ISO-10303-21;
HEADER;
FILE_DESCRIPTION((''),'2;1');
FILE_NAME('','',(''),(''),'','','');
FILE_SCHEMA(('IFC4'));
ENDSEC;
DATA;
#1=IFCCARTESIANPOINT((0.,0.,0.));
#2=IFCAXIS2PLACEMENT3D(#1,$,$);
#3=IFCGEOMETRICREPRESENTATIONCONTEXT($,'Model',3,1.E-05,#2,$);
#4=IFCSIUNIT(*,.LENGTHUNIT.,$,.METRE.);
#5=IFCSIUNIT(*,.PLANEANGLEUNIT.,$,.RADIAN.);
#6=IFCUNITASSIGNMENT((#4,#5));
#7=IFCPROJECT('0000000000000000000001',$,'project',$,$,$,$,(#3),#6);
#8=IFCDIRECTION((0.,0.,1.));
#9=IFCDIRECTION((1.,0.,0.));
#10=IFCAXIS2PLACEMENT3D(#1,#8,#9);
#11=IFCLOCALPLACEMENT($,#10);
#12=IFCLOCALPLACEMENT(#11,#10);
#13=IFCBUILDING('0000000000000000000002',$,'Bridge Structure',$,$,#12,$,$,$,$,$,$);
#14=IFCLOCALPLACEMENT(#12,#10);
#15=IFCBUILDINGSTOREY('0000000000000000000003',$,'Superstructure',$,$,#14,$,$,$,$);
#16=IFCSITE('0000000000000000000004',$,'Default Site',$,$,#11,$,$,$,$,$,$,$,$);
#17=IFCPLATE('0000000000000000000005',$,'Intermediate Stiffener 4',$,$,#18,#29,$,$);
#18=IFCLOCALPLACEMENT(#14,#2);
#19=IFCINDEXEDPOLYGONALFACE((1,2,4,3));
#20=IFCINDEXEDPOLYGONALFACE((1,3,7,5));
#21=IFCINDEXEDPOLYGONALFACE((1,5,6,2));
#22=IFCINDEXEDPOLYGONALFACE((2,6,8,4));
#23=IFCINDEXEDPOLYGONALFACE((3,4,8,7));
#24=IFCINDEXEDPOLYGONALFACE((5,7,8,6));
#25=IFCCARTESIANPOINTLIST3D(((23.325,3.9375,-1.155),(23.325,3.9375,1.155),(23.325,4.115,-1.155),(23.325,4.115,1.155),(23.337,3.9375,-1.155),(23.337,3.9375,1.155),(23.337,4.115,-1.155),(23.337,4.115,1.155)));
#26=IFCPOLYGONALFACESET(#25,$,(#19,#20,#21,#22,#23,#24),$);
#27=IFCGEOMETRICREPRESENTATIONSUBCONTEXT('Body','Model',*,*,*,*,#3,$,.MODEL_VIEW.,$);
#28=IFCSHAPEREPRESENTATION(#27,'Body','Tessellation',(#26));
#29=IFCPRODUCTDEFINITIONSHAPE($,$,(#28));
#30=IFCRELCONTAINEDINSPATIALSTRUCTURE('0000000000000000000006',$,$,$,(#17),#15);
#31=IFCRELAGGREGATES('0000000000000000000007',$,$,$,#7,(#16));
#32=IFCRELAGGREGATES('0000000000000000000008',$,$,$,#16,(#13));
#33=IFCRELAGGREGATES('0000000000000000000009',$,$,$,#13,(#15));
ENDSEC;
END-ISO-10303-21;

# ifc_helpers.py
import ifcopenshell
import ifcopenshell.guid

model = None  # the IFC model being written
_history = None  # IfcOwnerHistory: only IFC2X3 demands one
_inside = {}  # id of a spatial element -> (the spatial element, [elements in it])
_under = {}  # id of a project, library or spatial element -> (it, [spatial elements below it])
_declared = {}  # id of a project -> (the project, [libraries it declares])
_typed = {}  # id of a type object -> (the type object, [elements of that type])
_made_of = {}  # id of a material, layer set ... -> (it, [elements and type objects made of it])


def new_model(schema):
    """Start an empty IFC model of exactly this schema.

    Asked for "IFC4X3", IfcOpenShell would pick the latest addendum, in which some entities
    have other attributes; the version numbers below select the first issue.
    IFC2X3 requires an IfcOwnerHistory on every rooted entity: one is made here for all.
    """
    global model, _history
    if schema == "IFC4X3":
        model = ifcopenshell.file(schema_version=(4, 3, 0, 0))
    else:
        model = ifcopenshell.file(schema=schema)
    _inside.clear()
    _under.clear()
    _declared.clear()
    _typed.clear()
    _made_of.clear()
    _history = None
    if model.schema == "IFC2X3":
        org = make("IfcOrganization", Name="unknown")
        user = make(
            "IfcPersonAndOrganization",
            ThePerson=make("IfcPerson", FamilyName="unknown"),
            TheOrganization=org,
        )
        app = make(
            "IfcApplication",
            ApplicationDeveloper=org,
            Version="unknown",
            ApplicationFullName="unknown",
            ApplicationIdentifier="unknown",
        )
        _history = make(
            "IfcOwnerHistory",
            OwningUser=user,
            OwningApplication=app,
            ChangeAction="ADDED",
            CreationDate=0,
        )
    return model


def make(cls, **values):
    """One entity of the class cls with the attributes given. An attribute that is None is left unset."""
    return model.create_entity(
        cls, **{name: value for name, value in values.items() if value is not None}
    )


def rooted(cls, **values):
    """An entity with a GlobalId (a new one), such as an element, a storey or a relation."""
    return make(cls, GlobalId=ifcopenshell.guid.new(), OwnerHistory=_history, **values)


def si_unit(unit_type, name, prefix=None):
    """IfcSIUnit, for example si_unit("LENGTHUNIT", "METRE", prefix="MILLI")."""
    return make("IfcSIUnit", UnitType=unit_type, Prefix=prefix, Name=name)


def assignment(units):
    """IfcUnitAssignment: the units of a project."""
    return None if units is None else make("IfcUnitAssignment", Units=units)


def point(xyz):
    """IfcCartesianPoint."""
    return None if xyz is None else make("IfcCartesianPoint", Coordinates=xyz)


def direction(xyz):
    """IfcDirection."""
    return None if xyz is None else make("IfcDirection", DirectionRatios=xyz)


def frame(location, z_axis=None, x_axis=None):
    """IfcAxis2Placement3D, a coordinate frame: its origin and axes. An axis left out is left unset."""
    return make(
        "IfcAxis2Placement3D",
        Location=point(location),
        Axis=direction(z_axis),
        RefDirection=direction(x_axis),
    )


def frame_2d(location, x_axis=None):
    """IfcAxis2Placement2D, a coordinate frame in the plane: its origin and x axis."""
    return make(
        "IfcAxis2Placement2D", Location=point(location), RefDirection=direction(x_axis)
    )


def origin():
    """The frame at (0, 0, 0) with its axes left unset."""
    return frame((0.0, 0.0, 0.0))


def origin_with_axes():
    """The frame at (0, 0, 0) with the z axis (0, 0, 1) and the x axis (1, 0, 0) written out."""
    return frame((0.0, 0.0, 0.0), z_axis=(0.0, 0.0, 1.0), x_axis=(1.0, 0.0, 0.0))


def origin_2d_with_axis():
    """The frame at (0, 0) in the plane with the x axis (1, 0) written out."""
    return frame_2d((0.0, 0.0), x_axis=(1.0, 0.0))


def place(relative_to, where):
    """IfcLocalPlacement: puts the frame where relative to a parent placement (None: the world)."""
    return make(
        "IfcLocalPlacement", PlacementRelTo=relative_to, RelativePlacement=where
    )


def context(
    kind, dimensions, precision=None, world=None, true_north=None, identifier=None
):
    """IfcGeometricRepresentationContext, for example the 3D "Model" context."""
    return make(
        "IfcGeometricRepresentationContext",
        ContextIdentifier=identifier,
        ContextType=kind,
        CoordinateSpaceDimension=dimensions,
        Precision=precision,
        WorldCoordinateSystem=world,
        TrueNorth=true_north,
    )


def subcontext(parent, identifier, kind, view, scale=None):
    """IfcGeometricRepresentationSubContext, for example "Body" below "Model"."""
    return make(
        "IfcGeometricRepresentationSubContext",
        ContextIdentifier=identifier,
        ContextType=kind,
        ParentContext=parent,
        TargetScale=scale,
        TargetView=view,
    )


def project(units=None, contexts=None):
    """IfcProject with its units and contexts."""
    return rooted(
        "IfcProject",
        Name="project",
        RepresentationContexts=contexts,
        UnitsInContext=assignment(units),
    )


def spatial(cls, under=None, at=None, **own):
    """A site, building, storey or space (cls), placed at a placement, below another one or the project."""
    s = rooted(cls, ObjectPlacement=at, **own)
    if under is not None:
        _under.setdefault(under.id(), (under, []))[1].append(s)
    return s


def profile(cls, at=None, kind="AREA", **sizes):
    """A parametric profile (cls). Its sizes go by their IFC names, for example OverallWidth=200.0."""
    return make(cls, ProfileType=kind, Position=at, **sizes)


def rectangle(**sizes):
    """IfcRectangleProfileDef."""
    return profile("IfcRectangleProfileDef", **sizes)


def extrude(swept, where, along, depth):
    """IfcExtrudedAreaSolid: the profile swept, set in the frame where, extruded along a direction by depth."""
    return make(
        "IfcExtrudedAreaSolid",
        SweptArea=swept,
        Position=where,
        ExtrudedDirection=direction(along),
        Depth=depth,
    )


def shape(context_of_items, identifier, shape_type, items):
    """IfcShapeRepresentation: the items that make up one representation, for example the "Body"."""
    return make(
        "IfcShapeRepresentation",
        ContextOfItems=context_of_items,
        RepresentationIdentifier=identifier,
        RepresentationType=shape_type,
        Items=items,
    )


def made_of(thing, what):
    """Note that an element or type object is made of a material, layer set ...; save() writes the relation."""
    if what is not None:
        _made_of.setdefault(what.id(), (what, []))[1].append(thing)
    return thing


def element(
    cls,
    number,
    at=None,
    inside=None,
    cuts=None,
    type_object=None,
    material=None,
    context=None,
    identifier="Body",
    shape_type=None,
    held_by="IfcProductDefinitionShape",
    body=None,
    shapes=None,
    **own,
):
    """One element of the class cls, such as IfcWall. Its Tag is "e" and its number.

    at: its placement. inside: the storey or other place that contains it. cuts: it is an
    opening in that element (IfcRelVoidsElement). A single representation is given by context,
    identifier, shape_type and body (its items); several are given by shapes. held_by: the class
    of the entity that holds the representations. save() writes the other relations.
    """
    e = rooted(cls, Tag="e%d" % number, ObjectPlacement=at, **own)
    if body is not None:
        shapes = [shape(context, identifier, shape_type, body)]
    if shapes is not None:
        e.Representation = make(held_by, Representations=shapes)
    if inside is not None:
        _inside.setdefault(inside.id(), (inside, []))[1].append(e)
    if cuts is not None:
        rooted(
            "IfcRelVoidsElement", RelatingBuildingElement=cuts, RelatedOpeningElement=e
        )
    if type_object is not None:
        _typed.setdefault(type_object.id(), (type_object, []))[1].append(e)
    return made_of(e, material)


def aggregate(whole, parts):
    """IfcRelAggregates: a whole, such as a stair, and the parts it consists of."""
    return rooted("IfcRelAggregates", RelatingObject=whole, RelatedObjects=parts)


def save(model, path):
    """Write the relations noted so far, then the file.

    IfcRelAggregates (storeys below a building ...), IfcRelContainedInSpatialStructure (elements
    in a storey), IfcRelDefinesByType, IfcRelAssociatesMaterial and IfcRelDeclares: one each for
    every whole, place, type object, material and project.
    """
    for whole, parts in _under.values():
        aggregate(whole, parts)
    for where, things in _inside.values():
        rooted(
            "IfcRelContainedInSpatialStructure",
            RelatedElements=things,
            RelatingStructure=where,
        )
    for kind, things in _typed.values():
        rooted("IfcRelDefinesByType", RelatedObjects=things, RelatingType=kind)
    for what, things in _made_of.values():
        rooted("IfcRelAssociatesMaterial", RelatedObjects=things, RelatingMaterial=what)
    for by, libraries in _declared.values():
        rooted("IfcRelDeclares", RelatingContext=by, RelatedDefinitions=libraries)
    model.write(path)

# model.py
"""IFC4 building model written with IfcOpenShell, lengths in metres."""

from ifc_helpers import new_model, si_unit, frame, origin, origin_with_axes, origin_2d_with_axis, place, context, subcontext, project, spatial, rectangle, extrude, element, save


model = new_model("IFC4")

# Units and contexts
model_context = context("Model", 3, precision=1e-05, world=origin())
body_context = subcontext(model_context, "Body", "Model", "MODEL_VIEW")
ifc_project = project(units=[si_unit("LENGTHUNIT", "METRE"), si_unit("PLANEANGLEUNIT", "RADIAN")], contexts=[model_context])

# Site, building, storey
site_placement = place(None, origin_with_axes())
site = spatial("IfcSite", under=ifc_project, at=site_placement, Name="Default Site")
building_placement = place(site_placement, origin_with_axes())
building = spatial("IfcBuilding", under=site, at=building_placement, Name="Bridge Structure")
storey_placement = place(building_placement, origin_with_axes())
storey = spatial("IfcBuildingStorey", under=building, at=storey_placement, Name="Superstructure")

# Plate
for number, where, z_axis, x_axis, name in (
    (1, (23.331, 4.0263, -1.155), (0.0, 0.0, 1.0), (1.0, 0.0, 0.0), "Intermediate Stiffener 4"),
):
    element("IfcPlate", number, at=place(storey_placement, frame(where, z_axis=z_axis, x_axis=x_axis)), inside=storey, Name=name, context=body_context, shape_type="SweptSolid", body=[
        extrude(rectangle(XDim=0.012, YDim=0.1775, at=origin_2d_with_axis()), origin_with_axes(), (0.0, 0.0, 1.0), 2.31),
    ])

save(model, "model.ifc")
